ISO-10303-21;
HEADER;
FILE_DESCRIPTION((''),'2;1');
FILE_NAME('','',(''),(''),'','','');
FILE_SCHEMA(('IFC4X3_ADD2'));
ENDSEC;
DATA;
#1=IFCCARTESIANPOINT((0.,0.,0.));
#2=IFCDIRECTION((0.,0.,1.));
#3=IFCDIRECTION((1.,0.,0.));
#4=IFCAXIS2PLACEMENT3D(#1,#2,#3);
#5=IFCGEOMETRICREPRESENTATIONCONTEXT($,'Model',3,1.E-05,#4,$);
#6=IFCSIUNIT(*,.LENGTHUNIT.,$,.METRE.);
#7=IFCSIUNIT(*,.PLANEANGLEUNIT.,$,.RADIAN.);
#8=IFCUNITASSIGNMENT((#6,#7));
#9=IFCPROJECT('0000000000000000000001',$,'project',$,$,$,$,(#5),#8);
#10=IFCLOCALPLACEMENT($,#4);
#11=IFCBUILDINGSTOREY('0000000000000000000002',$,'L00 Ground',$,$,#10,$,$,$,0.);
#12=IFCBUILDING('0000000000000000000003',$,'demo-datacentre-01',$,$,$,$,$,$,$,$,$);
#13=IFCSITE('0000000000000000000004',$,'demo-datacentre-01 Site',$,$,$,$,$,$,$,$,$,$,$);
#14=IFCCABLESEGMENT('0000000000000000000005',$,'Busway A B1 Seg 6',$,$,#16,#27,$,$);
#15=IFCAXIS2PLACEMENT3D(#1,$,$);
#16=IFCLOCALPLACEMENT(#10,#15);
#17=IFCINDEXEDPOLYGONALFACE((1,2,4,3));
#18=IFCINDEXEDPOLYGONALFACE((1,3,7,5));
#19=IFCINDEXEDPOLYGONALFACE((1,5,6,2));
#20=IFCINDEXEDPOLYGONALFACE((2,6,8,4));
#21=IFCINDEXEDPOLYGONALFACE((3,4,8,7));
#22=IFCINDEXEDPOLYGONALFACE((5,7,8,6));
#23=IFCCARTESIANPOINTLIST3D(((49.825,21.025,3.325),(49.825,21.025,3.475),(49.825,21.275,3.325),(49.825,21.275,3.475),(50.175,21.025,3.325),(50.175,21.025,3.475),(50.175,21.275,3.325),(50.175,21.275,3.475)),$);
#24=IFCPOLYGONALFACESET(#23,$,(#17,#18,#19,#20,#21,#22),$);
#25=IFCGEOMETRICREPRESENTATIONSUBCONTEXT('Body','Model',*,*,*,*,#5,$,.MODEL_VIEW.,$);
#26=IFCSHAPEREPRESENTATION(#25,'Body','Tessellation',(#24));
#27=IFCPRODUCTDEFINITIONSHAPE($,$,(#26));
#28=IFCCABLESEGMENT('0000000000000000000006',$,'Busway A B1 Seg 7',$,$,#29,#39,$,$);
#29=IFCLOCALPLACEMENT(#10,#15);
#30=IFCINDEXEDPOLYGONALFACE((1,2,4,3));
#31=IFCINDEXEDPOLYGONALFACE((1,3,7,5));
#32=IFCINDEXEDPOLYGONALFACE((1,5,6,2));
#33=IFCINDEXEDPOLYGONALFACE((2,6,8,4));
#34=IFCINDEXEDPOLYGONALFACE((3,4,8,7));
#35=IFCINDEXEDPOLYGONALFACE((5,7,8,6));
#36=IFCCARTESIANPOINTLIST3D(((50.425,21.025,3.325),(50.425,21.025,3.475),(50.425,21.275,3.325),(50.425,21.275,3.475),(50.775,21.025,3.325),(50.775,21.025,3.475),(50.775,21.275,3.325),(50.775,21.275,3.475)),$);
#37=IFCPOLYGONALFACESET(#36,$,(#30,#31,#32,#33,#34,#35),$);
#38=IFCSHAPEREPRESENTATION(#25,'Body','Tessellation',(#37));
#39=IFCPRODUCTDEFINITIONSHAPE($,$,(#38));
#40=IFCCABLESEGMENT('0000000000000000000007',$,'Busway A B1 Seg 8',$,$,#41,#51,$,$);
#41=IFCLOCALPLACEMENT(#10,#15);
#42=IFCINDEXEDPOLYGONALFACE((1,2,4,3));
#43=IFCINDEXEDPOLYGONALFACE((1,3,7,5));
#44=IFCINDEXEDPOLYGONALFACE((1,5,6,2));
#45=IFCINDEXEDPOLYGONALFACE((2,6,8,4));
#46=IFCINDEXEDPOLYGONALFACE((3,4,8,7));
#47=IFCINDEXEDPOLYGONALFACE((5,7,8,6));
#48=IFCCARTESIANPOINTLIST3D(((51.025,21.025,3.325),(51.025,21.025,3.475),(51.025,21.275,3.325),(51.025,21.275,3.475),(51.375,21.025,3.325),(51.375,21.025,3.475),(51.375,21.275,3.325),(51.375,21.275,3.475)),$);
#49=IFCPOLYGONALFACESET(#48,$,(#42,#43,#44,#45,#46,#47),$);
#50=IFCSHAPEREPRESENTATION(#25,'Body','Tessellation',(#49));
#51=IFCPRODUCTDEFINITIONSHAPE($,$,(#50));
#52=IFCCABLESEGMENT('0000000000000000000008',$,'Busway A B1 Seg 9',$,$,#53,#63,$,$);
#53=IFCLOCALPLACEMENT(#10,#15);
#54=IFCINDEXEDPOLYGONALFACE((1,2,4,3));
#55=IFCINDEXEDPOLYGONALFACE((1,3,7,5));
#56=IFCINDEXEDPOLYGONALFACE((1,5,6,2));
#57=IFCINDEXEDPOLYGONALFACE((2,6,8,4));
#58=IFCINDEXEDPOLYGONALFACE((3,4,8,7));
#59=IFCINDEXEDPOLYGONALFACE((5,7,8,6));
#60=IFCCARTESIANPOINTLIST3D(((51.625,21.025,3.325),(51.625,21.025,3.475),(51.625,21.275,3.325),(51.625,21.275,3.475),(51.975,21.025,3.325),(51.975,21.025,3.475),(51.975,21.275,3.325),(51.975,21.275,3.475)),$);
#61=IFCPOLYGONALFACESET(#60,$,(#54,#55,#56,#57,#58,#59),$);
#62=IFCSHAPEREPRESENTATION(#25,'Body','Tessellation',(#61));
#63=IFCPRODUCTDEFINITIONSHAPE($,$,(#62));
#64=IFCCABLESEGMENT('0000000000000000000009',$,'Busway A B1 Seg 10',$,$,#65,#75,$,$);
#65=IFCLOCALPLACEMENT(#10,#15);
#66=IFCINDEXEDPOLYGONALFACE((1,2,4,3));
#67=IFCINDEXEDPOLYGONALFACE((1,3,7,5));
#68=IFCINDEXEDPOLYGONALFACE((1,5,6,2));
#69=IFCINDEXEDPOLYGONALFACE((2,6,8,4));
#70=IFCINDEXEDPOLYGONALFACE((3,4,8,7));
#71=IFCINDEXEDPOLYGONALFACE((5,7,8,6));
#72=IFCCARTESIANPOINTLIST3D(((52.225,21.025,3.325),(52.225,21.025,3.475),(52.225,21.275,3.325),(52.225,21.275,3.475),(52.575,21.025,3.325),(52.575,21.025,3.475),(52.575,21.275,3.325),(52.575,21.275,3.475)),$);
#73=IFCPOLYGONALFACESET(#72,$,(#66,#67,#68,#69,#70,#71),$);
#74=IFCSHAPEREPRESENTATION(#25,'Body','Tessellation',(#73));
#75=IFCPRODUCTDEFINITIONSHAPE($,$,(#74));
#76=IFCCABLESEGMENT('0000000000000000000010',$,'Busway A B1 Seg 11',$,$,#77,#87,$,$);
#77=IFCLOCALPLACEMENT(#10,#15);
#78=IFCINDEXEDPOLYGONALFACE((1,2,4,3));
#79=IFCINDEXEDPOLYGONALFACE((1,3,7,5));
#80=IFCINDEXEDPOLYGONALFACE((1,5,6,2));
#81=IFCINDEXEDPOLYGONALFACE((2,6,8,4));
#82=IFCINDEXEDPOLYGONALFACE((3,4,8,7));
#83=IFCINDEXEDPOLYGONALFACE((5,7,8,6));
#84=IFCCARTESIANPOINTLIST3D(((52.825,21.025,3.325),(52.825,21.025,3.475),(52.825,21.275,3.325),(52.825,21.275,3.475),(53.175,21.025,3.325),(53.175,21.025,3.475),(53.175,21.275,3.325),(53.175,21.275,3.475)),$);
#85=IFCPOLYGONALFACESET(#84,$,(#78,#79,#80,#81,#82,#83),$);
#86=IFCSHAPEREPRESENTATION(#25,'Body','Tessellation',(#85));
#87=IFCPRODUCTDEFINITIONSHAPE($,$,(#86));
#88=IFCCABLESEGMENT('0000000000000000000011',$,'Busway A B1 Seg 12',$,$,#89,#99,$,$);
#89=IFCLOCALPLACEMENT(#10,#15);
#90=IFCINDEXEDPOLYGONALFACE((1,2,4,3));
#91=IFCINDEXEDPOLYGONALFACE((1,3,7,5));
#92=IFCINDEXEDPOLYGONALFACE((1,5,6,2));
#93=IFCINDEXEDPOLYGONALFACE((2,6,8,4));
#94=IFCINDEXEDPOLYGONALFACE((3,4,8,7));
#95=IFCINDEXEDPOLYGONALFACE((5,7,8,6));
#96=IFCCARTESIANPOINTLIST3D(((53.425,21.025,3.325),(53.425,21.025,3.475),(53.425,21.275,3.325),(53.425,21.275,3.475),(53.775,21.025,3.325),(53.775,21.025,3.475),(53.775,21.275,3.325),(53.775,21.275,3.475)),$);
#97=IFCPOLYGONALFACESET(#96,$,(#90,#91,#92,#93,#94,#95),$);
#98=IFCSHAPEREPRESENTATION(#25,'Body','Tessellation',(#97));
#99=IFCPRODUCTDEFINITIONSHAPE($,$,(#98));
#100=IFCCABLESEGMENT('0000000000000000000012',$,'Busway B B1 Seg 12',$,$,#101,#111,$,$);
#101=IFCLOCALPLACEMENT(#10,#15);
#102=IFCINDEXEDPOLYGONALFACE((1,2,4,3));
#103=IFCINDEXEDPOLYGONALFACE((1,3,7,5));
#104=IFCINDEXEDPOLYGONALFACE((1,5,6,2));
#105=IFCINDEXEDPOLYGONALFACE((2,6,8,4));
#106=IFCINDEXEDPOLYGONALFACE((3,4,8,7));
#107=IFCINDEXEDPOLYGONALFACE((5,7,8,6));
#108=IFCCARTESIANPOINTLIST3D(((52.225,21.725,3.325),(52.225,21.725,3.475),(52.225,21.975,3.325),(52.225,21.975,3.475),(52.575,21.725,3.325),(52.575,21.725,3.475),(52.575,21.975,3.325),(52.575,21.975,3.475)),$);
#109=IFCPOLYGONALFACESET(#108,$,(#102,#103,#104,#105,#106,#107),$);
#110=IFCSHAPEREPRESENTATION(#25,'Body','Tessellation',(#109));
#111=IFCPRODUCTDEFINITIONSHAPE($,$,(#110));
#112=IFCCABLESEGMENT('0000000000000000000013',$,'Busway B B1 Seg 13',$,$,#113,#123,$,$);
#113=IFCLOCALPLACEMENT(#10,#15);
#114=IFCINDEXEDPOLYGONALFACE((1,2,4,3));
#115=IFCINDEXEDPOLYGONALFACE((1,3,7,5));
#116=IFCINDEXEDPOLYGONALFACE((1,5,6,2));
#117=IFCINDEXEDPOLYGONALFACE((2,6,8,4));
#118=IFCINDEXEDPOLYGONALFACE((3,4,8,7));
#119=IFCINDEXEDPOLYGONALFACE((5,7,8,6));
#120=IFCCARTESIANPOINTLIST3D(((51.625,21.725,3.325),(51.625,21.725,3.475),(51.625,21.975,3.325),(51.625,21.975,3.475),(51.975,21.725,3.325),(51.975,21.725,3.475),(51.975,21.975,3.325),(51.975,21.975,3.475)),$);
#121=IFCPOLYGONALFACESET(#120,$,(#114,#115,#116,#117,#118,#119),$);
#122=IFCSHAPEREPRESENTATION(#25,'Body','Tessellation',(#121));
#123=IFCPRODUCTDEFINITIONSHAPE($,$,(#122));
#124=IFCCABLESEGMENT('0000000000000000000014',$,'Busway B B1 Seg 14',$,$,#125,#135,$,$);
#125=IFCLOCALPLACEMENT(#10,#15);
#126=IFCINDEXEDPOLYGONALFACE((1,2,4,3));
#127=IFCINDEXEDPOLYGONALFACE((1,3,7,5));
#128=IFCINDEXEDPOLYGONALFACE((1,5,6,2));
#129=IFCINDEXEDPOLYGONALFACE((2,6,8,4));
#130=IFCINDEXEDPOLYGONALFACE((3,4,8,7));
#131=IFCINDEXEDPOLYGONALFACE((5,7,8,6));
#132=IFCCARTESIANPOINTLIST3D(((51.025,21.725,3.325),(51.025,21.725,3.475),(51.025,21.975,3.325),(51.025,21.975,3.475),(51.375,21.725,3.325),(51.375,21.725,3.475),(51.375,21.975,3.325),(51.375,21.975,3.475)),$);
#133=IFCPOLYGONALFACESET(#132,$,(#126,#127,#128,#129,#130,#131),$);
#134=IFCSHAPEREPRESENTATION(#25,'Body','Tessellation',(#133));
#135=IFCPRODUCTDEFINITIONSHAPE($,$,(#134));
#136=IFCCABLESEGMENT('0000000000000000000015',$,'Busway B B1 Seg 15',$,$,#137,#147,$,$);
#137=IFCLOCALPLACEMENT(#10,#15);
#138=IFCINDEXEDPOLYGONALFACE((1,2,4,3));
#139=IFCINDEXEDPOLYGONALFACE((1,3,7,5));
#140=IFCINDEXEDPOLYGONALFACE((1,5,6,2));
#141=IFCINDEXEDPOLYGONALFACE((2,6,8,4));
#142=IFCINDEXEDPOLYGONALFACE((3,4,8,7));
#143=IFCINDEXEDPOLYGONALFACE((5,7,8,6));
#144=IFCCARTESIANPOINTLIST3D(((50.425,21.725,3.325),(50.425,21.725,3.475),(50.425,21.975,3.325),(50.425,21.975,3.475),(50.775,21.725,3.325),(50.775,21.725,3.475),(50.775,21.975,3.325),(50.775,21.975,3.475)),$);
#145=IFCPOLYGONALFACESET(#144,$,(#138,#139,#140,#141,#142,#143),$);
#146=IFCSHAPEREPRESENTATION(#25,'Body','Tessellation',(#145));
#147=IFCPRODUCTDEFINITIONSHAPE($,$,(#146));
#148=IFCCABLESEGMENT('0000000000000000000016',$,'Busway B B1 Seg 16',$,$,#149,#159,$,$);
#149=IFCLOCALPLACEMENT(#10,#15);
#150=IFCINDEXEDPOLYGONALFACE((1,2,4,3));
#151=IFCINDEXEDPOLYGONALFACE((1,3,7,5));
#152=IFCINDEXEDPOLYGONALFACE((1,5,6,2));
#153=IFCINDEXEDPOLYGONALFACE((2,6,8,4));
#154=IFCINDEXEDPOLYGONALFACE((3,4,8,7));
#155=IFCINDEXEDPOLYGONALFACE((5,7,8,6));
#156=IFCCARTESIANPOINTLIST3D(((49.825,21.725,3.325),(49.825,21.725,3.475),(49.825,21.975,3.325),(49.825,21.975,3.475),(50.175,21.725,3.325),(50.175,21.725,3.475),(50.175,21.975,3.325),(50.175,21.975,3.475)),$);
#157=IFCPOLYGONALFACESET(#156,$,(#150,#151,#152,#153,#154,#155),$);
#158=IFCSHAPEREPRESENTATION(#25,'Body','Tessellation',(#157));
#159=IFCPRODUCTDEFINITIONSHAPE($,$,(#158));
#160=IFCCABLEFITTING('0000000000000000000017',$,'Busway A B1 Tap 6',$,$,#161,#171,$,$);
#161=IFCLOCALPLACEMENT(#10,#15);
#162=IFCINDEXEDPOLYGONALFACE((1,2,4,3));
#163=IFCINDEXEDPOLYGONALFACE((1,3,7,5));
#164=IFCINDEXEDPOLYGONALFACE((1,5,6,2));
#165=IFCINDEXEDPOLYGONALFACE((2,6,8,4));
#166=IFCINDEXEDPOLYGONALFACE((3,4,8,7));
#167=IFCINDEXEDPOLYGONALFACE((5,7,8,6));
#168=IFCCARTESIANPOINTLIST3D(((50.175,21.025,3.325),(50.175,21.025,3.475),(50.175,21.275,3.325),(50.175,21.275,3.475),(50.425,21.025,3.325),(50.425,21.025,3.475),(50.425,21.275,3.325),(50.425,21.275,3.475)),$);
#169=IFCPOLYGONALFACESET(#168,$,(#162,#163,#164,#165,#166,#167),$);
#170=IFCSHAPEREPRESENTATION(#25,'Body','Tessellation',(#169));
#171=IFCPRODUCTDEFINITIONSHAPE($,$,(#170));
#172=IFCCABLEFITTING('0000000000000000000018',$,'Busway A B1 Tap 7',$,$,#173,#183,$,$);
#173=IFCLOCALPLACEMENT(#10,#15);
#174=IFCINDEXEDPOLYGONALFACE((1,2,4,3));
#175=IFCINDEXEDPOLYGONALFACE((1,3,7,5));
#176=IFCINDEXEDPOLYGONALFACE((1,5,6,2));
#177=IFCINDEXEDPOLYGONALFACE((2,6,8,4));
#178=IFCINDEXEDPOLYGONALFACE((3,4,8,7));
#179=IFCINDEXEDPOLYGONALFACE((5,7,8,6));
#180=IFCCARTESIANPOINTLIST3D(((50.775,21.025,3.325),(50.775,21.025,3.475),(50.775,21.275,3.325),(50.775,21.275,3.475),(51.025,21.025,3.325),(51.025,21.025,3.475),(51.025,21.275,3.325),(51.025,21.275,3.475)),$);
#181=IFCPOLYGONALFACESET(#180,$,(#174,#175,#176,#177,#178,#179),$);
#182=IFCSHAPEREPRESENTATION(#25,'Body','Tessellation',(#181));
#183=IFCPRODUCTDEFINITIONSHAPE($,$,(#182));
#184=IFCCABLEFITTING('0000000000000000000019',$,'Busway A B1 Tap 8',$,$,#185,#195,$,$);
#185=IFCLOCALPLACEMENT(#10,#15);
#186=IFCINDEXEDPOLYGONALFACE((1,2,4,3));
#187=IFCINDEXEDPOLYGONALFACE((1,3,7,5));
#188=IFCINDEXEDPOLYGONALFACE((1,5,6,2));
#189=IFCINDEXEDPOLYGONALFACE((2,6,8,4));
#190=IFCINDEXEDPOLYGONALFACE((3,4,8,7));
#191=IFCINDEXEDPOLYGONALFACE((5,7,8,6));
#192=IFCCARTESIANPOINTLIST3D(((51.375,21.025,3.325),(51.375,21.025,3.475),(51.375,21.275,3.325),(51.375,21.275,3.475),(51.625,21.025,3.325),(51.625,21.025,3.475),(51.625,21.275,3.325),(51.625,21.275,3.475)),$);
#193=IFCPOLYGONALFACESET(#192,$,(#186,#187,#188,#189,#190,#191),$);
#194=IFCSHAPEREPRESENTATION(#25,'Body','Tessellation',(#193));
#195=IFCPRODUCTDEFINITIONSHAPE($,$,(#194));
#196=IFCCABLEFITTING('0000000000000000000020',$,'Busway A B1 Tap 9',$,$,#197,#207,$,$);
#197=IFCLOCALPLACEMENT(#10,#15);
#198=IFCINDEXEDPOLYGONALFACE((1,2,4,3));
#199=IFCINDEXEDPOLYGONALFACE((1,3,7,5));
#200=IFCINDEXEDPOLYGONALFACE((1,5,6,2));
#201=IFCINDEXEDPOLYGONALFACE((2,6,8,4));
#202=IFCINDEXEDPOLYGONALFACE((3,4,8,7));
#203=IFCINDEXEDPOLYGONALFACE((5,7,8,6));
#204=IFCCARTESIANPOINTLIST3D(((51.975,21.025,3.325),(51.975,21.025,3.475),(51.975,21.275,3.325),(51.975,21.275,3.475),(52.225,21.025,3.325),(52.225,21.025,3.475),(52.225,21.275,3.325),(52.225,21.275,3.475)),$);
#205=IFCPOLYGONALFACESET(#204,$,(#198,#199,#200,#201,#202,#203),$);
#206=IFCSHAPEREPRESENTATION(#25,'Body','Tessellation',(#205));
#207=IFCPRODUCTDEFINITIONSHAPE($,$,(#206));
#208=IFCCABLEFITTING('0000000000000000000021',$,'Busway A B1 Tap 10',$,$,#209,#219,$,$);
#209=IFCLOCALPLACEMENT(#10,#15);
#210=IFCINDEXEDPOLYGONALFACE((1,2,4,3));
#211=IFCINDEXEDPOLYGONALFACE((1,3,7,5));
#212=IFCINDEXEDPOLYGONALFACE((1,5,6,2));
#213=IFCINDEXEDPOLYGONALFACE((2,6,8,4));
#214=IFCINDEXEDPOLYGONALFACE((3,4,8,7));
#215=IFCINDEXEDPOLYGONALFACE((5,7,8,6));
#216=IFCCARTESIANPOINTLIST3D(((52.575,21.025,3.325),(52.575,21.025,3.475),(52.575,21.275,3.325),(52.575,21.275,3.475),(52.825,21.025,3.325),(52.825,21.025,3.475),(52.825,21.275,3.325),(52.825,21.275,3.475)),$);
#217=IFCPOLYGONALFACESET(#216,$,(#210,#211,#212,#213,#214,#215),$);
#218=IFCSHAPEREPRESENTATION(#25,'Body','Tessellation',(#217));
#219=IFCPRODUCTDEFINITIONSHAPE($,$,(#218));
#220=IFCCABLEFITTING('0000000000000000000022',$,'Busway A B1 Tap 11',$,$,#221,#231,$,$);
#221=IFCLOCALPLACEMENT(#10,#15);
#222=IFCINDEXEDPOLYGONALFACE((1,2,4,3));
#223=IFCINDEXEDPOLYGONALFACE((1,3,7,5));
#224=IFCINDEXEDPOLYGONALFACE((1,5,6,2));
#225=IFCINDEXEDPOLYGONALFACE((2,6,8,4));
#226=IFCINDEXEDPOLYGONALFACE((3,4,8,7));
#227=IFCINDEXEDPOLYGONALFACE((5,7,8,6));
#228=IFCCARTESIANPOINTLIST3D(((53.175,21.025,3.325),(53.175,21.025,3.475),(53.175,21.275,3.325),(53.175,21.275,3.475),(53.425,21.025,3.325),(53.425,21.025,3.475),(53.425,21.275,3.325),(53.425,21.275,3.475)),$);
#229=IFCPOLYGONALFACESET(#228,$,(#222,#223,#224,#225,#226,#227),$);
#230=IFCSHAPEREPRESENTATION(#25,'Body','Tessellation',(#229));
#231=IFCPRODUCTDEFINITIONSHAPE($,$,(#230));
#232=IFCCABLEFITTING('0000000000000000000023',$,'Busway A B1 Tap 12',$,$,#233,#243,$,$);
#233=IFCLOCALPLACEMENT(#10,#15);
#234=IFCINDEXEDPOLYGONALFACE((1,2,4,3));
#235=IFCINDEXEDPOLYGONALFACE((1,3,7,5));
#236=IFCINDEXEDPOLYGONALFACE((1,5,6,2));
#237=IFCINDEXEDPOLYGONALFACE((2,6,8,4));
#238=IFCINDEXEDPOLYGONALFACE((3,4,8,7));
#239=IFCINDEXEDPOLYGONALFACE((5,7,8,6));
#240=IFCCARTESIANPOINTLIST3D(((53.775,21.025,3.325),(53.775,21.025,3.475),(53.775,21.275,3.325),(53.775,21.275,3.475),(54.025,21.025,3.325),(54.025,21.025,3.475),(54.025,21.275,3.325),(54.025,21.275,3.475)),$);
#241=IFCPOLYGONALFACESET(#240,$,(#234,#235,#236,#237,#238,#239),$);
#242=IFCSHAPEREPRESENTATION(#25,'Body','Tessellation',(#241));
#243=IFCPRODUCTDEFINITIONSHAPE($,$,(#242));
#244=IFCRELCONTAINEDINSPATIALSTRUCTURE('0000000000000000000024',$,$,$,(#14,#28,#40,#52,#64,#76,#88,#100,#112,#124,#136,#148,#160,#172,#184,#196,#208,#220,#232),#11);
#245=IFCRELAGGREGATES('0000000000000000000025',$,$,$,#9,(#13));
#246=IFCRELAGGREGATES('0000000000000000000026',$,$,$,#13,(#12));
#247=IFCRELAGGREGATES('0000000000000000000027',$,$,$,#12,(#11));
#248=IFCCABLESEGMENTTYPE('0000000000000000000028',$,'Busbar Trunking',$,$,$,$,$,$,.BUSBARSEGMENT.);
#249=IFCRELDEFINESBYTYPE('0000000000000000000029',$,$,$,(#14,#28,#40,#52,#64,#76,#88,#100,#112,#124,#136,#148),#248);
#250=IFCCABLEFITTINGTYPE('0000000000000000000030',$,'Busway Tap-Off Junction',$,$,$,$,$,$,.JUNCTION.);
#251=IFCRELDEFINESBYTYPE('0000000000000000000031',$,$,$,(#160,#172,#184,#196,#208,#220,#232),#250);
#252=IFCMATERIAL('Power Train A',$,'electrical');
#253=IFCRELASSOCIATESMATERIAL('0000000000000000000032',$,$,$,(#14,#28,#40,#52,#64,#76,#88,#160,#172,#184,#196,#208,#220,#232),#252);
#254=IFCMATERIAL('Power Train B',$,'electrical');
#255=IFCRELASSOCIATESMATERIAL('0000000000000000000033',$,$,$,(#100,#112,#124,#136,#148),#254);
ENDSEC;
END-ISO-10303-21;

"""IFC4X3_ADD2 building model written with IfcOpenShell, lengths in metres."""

from ifc_helpers import new_model, si_unit, frame, origin_with_axes, place, context, subcontext, project, spatial, rectangle, extrude, material, type_object, element, save


model = new_model("IFC4X3_ADD2")

# Units and contexts
model_context = context("Model", 3, precision=1e-05, world=origin_with_axes())
body_context = subcontext(model_context, "Body", "Model", "MODEL_VIEW")
ifc_project = project(units=[si_unit("LENGTHUNIT", "METRE"), si_unit("PLANEANGLEUNIT", "RADIAN")], contexts=[model_context])

# Site, building, storey
site = spatial("IfcSite", under=ifc_project, Name="demo-datacentre-01 Site")
building = spatial("IfcBuilding", under=site, Name="demo-datacentre-01")
storey_placement = place(None, origin_with_axes())
storey = spatial("IfcBuildingStorey", under=building, at=storey_placement, Name="L00 Ground", Elevation=0.0)

# Cable segments
ifc_material_1 = material(Name="Power Train A", Category="electrical")
cable_segment_type_1 = type_object("IfcCableSegmentType", Name="Busbar Trunking", PredefinedType="BUSBARSEGMENT")
for number, where, z_axis, x_axis, name in (
    (1, (49.825, 21.15, 3.4), (1.0, 0.0, 0.0), (0.0, 1.0, 0.0), "Busway A B1 Seg 6"),
    (2, (50.425, 21.15, 3.4), (1.0, 0.0, 0.0), (0.0, 1.0, 0.0), "Busway A B1 Seg 7"),
    (3, (51.025, 21.15, 3.4), (1.0, 0.0, 0.0), (0.0, 1.0, 0.0), "Busway A B1 Seg 8"),
):
    element("IfcCableSegment", number, at=place(storey_placement, frame(where, z_axis=z_axis, x_axis=x_axis)), inside=storey, type_object=cable_segment_type_1, material=ifc_material_1, Name=name, context=body_context, shape_type="SweptSolid", body=[
        extrude(rectangle(XDim=0.25, YDim=0.15), origin_with_axes(), (0.0, 0.0, 1.0), 0.35),
    ])
cable_segment_1_placement = place(storey_placement, frame((51.625, 21.15, 3.4), z_axis=(1.0, 0.0, 0.0), x_axis=(0.0, 1.0, 0.0)))
element("IfcCableSegment", 4, at=cable_segment_1_placement, inside=storey, type_object=cable_segment_type_1, material=ifc_material_1, Name="Busway A B1 Seg 9", context=body_context, shape_type="SweptSolid", body=[
    extrude(rectangle(XDim=0.25, YDim=0.15), origin_with_axes(), (0.0, 0.0, 1.0), 0.35),
])
for number, where, z_axis, x_axis, name in (
    (5, (52.225, 21.15, 3.4), (1.0, 0.0, 0.0), (0.0, 1.0, 0.0), "Busway A B1 Seg 10"),
    (6, (52.825, 21.15, 3.4), (1.0, 0.0, 0.0), (0.0, 1.0, 0.0), "Busway A B1 Seg 11"),
    (7, (53.425, 21.15, 3.4), (1.0, 0.0, 0.0), (0.0, 1.0, 0.0), "Busway A B1 Seg 12"),
):
    element("IfcCableSegment", number, at=place(storey_placement, frame(where, z_axis=z_axis, x_axis=x_axis)), inside=storey, type_object=cable_segment_type_1, material=ifc_material_1, Name=name, context=body_context, shape_type="SweptSolid", body=[
        extrude(rectangle(XDim=0.25, YDim=0.15), origin_with_axes(), (0.0, 0.0, 1.0), 0.35),
    ])
ifc_material_2 = material(Name="Power Train B", Category="electrical")
cable_segment_2_placement = place(storey_placement, frame((52.575, 21.85, 3.4), z_axis=(-1.0, 0.0, 0.0), x_axis=(0.0, -1.0, 0.0)))
element("IfcCableSegment", 8, at=cable_segment_2_placement, inside=storey, type_object=cable_segment_type_1, material=ifc_material_2, Name="Busway B B1 Seg 12", context=body_context, shape_type="SweptSolid", body=[
    extrude(rectangle(XDim=0.25, YDim=0.15), origin_with_axes(), (0.0, 0.0, 1.0), 0.35),
])
cable_segment_3_placement = place(storey_placement, frame((51.975, 21.85, 3.4), z_axis=(-1.0, 0.0, 0.0), x_axis=(0.0, -1.0, 0.0)))
element("IfcCableSegment", 9, at=cable_segment_3_placement, inside=storey, type_object=cable_segment_type_1, material=ifc_material_2, Name="Busway B B1 Seg 13", context=body_context, shape_type="SweptSolid", body=[
    extrude(rectangle(XDim=0.25, YDim=0.15), origin_with_axes(), (0.0, 0.0, 1.0), 0.35),
])
for number, where, z_axis, x_axis, name in (
    (10, (51.375, 21.85, 3.4), (-1.0, 0.0, 0.0), (0.0, -1.0, 0.0), "Busway B B1 Seg 14"),
    (11, (50.775, 21.85, 3.4), (-1.0, 0.0, 0.0), (0.0, -1.0, 0.0), "Busway B B1 Seg 15"),
    (12, (50.175, 21.85, 3.4), (-1.0, 0.0, 0.0), (0.0, -1.0, 0.0), "Busway B B1 Seg 16"),
):
    element("IfcCableSegment", number, at=place(storey_placement, frame(where, z_axis=z_axis, x_axis=x_axis)), inside=storey, type_object=cable_segment_type_1, material=ifc_material_2, Name=name, context=body_context, shape_type="SweptSolid", body=[
        extrude(rectangle(XDim=0.25, YDim=0.15), origin_with_axes(), (0.0, 0.0, 1.0), 0.35),
    ])

# Cable fittings
cable_fitting_type = type_object("IfcCableFittingType", Name="Busway Tap-Off Junction", PredefinedType="JUNCTION")
for number, where, z_axis, x_axis, name in (
    (13, (50.3, 21.15, 3.325), (0.0, 0.0, 1.0), (1.0, 0.0, 0.0), "Busway A B1 Tap 6"),
    (14, (50.9, 21.15, 3.325), (0.0, 0.0, 1.0), (1.0, 0.0, 0.0), "Busway A B1 Tap 7"),
    (15, (51.5, 21.15, 3.325), (0.0, 0.0, 1.0), (1.0, 0.0, 0.0), "Busway A B1 Tap 8"),
    (16, (52.1, 21.15, 3.325), (0.0, 0.0, 1.0), (1.0, 0.0, 0.0), "Busway A B1 Tap 9"),
    (17, (52.7, 21.15, 3.325), (0.0, 0.0, 1.0), (1.0, 0.0, 0.0), "Busway A B1 Tap 10"),
    (18, (53.3, 21.15, 3.325), (0.0, 0.0, 1.0), (1.0, 0.0, 0.0), "Busway A B1 Tap 11"),
    (19, (53.9, 21.15, 3.325), (0.0, 0.0, 1.0), (1.0, 0.0, 0.0), "Busway A B1 Tap 12"),
):
    element("IfcCableFitting", number, at=place(storey_placement, frame(where, z_axis=z_axis, x_axis=x_axis)), inside=storey, type_object=cable_fitting_type, material=ifc_material_1, Name=name, context=body_context, shape_type="SweptSolid", body=[
        extrude(rectangle(XDim=0.25, YDim=0.25), origin_with_axes(), (0.0, 0.0, 1.0), 0.15),
    ])

save(model, "model.ifc")
